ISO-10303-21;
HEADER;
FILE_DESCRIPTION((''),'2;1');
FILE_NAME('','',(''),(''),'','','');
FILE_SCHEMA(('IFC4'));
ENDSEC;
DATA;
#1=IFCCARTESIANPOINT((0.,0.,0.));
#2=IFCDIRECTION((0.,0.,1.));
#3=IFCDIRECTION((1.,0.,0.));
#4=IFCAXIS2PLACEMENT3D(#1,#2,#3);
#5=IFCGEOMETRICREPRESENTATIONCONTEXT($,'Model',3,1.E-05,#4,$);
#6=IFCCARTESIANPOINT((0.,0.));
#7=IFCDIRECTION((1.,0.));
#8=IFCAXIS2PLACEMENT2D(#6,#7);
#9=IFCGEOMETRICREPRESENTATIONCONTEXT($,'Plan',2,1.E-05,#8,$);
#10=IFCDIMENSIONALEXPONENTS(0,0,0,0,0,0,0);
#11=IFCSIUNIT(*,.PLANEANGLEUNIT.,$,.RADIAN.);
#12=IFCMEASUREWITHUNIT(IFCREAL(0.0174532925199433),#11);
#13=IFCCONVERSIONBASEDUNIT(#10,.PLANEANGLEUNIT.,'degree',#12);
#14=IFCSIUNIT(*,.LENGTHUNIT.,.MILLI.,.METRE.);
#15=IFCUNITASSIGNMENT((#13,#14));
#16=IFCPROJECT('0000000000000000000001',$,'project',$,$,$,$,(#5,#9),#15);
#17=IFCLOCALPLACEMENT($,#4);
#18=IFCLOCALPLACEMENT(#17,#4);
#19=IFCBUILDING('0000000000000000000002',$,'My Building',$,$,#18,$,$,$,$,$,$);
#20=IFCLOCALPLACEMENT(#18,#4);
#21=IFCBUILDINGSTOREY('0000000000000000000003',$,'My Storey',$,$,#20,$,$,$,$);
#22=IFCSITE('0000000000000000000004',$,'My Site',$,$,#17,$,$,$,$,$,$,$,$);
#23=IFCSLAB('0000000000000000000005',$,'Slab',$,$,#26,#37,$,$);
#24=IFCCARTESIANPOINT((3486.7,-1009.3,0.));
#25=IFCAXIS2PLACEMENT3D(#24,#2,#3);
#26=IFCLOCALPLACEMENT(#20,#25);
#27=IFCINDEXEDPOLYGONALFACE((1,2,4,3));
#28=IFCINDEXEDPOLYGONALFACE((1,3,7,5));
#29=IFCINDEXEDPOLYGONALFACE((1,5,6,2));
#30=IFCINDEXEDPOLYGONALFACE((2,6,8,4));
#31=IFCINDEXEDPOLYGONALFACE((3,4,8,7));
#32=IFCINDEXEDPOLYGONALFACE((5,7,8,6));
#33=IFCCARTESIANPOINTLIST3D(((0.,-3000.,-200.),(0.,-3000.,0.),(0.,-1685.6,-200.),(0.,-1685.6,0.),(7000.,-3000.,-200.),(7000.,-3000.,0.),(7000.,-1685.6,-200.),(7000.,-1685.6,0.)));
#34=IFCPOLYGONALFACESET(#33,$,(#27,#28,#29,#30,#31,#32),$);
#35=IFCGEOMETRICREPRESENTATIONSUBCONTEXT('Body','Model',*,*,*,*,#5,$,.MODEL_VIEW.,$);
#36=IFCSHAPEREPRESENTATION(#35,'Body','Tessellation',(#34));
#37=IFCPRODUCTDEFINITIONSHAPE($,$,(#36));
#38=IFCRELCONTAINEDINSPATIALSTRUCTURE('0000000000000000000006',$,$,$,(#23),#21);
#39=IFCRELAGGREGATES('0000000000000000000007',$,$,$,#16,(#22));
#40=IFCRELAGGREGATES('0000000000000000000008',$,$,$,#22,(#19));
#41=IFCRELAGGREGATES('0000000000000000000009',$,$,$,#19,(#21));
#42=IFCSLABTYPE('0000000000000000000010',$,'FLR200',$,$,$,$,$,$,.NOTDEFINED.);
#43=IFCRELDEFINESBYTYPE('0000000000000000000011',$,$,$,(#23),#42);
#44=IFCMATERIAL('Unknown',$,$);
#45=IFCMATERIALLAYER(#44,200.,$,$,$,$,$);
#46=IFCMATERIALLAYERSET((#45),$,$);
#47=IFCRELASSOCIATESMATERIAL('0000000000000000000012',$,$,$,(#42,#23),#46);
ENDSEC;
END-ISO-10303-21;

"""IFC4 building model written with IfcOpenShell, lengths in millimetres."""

from ifc_helpers import new_model, entity, si_unit, converted_unit, frame, origin_with_axes, origin_2d_with_axis, place, context, subcontext, project, spatial, indexed_curve, outline, extrude, material, layer, layer_set, layer_usage, type_object, element, save


model = new_model("IFC4")

# Units and contexts
model_context = context("Model", 3, precision=1e-05, world=origin_with_axes())
plan_context = context("Plan", 2, precision=1e-05, world=origin_2d_with_axis())
body_context = subcontext(model_context, "Body", "Model", "MODEL_VIEW")
ifc_project = project(units=[converted_unit("PLANEANGLEUNIT", "degree", entity("IfcReal", 0.0174532925199433), si_unit("PLANEANGLEUNIT", "RADIAN"), dimensions=[0, 0, 0, 0, 0, 0, 0]), si_unit("LENGTHUNIT", "METRE", prefix="MILLI")], contexts=[model_context, plan_context])

# Site, building, storey
site_placement = place(None, origin_with_axes())
site = spatial("IfcSite", under=ifc_project, at=site_placement, Name="My Site")
building_placement = place(site_placement, origin_with_axes())
building = spatial("IfcBuilding", under=site, at=building_placement, Name="My Building")
storey_placement = place(building_placement, origin_with_axes())
storey = spatial("IfcBuildingStorey", under=building, at=storey_placement, Name="My Storey")

# Slab
ifc_material = material(Name="Unknown")
ifc_layer_1 = layer(ifc_material, 200.0)
ifc_layer_set_1 = layer_set([ifc_layer_1])
slab_type_1 = type_object("IfcSlabType", Name="FLR200", PredefinedType="NOTDEFINED", material=ifc_layer_set_1)
ifc_layer_usage_1 = layer_usage(ifc_layer_set_1, "AXIS3", "POSITIVE", -200.0)
slab_1_placement = place(storey_placement, frame((3486.7, -1009.3, 0.0), z_axis=(0.0, 0.0, 1.0), x_axis=(1.0, 0.0, 0.0)))
element("IfcSlab", 1, at=slab_1_placement, inside=storey, type_object=slab_type_1, material=ifc_layer_usage_1, Name="Slab", context=body_context, shape_type="SweptSolid", body=[
    extrude(outline(indexed_curve([(7000.0, -1685.6), (7000.0, -3000.0), (0.0, -3000.0), (0.0, -1685.6), (7000.0, -1685.6)])), frame((0.0, 0.0, -200.0), z_axis=(0.0, 0.0, 1.0), x_axis=(1.0, 0.0, 0.0)), (0.0, 0.0, 1.0), 200.0),
])

save(model, "model.ifc")
